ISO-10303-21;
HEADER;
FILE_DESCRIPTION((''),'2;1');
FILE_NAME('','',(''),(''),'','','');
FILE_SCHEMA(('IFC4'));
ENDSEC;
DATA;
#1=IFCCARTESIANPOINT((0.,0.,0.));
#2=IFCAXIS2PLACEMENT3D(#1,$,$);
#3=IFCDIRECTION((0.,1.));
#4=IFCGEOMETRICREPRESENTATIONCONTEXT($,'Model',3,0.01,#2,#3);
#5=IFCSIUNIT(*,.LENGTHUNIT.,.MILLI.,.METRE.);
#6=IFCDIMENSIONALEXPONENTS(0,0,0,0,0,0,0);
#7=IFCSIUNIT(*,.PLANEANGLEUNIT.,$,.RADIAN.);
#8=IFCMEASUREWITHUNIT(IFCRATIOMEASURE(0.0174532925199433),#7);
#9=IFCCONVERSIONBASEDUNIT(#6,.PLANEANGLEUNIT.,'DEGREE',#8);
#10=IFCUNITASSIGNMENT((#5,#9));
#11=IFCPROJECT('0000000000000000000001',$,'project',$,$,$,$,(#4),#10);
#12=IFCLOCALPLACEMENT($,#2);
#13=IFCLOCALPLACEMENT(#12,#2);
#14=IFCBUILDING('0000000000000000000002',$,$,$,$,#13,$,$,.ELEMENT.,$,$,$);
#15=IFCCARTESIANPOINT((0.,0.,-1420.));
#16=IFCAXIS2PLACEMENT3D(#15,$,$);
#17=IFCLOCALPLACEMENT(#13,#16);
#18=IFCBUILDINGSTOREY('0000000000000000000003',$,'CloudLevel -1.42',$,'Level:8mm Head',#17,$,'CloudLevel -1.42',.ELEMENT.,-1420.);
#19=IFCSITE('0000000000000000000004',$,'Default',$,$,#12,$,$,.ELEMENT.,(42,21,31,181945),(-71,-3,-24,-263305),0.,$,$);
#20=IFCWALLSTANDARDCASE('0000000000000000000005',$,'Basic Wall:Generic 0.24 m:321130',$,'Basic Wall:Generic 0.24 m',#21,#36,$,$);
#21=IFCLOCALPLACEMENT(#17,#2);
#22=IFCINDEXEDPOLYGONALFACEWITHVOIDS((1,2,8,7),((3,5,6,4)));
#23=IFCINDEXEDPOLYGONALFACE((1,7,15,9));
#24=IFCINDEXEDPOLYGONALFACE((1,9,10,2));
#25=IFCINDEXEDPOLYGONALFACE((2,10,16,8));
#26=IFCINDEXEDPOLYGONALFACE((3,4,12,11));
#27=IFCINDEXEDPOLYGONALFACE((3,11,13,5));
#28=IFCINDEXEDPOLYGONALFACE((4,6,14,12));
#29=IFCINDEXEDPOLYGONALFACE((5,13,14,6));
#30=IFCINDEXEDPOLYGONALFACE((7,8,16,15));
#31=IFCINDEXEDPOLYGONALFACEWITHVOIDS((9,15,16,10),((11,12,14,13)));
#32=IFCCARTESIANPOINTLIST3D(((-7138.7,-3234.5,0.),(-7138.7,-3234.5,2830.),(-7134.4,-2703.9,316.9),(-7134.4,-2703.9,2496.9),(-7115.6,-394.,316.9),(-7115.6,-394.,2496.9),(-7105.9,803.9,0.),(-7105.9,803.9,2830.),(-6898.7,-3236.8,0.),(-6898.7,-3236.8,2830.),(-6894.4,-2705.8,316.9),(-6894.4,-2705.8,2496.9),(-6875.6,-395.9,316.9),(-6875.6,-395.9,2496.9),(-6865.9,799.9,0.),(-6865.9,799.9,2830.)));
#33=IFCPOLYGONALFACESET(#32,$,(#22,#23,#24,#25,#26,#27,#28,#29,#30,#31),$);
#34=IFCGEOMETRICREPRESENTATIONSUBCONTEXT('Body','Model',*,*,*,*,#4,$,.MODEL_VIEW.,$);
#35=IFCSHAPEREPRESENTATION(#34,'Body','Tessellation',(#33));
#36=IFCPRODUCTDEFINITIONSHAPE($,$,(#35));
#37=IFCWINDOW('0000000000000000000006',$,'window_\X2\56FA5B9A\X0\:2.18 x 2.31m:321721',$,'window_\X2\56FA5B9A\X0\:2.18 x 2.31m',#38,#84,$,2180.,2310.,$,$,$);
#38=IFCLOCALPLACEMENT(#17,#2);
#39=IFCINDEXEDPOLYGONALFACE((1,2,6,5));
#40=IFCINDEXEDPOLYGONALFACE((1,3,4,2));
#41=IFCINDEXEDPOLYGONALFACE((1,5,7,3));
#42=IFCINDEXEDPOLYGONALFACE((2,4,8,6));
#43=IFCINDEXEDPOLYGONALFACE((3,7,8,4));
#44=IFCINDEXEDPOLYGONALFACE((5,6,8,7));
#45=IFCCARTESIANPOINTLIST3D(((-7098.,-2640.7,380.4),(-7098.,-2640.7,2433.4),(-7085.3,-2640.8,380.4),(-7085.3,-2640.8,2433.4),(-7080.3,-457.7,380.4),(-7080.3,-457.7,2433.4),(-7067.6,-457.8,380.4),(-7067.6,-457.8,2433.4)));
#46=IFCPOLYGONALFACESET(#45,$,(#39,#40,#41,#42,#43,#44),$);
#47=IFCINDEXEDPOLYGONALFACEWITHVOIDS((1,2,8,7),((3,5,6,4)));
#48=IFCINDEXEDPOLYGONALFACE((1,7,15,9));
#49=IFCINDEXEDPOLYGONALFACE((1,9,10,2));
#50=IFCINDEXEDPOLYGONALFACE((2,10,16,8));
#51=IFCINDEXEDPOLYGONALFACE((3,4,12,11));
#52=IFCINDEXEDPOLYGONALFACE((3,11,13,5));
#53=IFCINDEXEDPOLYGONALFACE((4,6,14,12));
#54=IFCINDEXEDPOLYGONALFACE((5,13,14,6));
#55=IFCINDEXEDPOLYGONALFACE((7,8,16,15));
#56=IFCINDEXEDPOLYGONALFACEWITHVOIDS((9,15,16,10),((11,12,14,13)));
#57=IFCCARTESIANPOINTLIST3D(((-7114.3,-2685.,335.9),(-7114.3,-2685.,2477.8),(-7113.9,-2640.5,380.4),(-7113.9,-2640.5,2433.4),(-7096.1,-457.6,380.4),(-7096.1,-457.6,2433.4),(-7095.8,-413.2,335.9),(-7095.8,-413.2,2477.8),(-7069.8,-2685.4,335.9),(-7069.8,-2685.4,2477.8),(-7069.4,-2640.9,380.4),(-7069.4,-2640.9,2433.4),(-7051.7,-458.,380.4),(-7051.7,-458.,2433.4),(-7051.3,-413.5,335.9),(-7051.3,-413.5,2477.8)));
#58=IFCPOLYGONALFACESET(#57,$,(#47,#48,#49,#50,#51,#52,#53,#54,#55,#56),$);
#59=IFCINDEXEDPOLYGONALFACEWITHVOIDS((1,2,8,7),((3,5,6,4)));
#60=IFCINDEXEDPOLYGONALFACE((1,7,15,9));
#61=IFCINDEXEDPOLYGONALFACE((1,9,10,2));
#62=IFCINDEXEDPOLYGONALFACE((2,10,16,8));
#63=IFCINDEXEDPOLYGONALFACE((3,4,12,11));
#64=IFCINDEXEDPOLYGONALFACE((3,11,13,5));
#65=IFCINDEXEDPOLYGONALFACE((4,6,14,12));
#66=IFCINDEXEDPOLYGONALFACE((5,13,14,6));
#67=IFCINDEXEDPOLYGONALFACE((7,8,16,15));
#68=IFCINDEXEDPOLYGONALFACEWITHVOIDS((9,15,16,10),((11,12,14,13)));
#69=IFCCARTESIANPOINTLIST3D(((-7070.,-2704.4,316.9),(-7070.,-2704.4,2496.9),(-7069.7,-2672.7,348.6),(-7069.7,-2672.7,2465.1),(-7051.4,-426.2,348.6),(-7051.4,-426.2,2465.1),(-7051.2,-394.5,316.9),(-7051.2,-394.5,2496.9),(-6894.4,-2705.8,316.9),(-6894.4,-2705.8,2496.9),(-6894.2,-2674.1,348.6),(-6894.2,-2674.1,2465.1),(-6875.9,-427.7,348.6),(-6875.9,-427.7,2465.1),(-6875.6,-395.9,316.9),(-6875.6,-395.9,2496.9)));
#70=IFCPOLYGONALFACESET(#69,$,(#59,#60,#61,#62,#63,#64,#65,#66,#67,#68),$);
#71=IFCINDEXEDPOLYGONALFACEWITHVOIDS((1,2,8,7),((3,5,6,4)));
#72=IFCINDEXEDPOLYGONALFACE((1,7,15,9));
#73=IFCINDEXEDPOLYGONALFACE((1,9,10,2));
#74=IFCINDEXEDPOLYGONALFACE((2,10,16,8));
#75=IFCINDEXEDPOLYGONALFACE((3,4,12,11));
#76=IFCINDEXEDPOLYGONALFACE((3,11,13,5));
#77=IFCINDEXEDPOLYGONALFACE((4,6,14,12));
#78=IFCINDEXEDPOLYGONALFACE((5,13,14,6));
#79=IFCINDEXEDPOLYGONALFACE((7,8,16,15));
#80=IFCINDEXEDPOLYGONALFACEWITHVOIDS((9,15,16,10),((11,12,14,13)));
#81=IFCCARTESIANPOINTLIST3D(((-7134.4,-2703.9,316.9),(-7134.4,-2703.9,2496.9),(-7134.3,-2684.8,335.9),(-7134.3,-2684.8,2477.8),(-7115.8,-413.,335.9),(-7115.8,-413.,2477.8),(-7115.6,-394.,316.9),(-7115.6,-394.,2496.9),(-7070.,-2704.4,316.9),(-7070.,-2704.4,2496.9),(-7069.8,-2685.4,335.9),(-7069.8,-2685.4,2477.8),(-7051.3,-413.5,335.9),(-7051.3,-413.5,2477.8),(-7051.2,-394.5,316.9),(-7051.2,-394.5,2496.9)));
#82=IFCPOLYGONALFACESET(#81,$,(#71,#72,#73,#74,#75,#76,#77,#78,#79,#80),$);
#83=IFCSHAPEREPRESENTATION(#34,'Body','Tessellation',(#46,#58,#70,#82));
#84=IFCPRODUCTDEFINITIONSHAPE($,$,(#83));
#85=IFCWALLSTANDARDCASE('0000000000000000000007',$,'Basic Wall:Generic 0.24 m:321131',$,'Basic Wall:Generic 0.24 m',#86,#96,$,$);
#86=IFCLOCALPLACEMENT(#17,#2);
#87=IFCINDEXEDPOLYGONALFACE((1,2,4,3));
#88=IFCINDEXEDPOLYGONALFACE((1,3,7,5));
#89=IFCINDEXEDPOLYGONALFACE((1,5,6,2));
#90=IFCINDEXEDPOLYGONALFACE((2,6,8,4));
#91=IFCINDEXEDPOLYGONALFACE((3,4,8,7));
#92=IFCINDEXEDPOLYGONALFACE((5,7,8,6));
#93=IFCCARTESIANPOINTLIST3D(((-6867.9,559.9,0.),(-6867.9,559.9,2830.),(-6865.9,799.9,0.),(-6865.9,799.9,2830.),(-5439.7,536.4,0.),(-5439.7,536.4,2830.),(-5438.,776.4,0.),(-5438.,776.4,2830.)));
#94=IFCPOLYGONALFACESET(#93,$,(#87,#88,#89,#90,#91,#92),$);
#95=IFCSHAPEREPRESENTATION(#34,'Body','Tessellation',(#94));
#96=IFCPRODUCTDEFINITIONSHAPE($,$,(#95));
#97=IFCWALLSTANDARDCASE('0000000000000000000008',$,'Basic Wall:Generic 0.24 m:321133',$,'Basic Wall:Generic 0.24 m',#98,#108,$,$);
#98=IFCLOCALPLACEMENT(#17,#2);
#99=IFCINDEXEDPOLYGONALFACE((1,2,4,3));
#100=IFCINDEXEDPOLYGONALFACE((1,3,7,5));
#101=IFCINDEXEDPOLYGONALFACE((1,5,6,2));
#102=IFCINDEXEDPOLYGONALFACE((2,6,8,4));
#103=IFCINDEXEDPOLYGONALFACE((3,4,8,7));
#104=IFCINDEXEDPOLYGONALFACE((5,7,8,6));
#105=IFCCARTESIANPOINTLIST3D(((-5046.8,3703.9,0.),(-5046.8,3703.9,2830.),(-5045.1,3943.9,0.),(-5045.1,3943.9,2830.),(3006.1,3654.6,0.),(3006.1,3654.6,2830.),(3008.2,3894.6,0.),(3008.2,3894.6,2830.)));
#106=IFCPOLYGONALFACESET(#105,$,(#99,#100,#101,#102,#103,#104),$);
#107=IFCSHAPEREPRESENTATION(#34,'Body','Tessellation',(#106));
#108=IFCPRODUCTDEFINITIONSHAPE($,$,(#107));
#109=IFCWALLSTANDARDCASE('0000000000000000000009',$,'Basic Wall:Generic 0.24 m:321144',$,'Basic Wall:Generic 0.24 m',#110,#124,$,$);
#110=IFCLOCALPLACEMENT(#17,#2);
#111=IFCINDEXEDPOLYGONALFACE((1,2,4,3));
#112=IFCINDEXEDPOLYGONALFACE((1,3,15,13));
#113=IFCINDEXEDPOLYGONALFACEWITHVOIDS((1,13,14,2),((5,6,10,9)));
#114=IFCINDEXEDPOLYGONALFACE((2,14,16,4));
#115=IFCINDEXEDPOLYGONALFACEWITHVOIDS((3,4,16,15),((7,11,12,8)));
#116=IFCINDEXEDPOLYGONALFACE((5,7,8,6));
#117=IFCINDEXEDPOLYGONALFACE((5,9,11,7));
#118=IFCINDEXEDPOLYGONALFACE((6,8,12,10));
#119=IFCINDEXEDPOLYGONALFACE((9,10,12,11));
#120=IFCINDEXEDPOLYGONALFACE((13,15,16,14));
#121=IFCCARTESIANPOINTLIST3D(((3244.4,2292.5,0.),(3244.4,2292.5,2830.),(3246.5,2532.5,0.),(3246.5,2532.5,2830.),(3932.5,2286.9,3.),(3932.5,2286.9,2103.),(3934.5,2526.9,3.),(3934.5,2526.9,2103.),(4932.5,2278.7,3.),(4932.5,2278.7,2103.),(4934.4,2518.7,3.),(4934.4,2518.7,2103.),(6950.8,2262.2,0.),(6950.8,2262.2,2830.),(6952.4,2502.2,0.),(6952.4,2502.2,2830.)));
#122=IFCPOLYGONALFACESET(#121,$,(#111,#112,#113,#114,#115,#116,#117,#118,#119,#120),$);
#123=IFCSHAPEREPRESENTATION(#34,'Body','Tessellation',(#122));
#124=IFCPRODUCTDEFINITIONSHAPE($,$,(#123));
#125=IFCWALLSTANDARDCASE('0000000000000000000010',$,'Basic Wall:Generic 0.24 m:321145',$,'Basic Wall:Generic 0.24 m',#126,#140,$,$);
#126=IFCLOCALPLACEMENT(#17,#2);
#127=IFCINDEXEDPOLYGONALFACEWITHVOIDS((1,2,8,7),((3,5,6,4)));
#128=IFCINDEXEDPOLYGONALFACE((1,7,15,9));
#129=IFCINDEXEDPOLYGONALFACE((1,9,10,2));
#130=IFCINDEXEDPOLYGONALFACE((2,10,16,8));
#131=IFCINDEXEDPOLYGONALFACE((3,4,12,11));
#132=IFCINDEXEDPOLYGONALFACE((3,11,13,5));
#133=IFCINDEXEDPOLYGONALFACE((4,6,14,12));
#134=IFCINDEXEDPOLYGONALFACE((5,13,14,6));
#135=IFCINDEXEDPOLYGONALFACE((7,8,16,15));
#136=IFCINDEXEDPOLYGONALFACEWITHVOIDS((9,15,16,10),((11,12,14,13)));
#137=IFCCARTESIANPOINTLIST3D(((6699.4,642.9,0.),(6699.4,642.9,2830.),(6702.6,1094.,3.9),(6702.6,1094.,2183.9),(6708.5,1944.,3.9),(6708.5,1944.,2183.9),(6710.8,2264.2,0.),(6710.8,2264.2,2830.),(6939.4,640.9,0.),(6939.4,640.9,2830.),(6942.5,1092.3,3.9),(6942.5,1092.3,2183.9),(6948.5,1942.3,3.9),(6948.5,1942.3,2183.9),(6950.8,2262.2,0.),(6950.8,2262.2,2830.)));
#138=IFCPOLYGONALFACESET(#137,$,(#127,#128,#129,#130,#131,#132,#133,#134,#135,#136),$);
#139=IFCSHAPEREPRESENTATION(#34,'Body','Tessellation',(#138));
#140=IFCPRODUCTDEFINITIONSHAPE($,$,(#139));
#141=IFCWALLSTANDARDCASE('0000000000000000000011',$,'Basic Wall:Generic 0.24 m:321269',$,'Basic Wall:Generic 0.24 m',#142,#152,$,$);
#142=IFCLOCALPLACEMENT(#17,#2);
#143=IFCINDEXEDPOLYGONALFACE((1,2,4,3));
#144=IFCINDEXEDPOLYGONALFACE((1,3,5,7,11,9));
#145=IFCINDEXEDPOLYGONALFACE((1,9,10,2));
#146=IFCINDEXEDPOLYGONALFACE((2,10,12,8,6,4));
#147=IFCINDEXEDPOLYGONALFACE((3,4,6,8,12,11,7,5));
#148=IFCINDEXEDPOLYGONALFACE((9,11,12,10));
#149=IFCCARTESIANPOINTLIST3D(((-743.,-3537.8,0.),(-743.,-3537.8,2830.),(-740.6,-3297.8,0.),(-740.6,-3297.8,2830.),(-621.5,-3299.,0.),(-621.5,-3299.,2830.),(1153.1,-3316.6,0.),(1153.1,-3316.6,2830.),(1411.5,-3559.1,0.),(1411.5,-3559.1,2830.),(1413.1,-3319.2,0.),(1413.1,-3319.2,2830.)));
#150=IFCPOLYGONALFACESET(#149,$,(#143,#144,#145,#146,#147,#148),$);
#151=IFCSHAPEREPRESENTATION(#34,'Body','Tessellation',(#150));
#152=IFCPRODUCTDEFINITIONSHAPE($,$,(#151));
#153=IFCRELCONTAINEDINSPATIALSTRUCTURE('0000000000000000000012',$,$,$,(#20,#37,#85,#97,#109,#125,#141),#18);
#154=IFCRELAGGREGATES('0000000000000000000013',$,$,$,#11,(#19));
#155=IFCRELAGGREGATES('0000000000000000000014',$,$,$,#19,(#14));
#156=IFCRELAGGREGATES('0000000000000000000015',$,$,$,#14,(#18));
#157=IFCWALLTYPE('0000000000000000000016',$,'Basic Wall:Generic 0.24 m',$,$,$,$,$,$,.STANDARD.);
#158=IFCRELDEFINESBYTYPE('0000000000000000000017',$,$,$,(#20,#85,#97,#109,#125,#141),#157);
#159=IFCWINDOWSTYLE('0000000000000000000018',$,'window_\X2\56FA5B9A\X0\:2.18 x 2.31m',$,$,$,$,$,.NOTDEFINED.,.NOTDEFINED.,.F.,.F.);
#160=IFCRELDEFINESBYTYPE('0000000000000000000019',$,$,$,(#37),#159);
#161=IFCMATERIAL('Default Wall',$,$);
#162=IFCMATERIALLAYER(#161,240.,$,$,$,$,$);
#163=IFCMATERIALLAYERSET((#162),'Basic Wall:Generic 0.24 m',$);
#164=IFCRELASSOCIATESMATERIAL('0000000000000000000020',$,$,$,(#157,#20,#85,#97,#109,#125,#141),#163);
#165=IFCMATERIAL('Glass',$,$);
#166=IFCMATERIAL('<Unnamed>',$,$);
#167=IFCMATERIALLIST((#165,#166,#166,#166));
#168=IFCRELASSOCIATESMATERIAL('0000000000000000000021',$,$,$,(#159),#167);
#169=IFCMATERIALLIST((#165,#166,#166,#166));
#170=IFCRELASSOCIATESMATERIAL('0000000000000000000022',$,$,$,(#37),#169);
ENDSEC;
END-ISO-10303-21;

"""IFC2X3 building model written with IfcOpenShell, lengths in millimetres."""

from ifc_helpers import new_model, entity, si_unit, converted_unit, direction, frame, frame_2d, origin, place, context, subcontext, project, spatial, polyline, rectangle, outline, extrude, source, transform, mapped, material, material_list, layer, layer_set, layer_usage, type_object, type_shapes, element, fill, save


model = new_model("IFC2X3")

# Units and contexts
model_context = context("Model", 3, precision=0.01, world=origin(), true_north=direction((0.0, 1.0)))
body_context = subcontext(model_context, "Body", "Model", "MODEL_VIEW")
ifc_project = project(units=[si_unit("LENGTHUNIT", "METRE", prefix="MILLI"), converted_unit("PLANEANGLEUNIT", "DEGREE", entity("IfcRatioMeasure", 0.0174532925199433), si_unit("PLANEANGLEUNIT", "RADIAN"), dimensions=[0, 0, 0, 0, 0, 0, 0])], contexts=[model_context])

# Site, building, storey
site_placement = place(None, origin())
site = spatial("IfcSite", under=ifc_project, at=site_placement, Name="Default", CompositionType="ELEMENT", RefLatitude=(42, 21, 31, 181945), RefLongitude=(-71, -3, -24, -263305), RefElevation=0.0)
building_placement = place(site_placement, origin())
building = spatial("IfcBuilding", under=site, at=building_placement, CompositionType="ELEMENT")
storey_placement = place(building_placement, frame((0.0, 0.0, -1420.0)))
storey = spatial("IfcBuildingStorey", under=building, at=storey_placement, Name="CloudLevel -1.42", ObjectType="Level:8mm Head", LongName="CloudLevel -1.42", CompositionType="ELEMENT", Elevation=-1420.0)

# Shared definitions
ifc_material_1 = material(Name="Default Wall")
ifc_layer_1 = layer(ifc_material_1, 240.0)
ifc_layer_set_1 = layer_set([ifc_layer_1], Name="Basic Wall:Generic 0.24 m")
wall_type_1 = type_object("IfcWallType", Name="Basic Wall:Generic 0.24 m", PredefinedType="STANDARD", material=ifc_layer_set_1)
ifc_material_2 = material(Name="Glass")
ifc_material_3 = material(Name="<Unnamed>")

# Wall, opening, window
ifc_layer_usage_1 = layer_usage(ifc_layer_set_1, "AXIS2", "NEGATIVE", 120.0)
wall_1_placement = place(storey_placement, frame((-6985.9, 802.9, 0.0), z_axis=(0.0, 0.0, 1.0), x_axis=(-0.008134, -0.999967, 0.0)))
wall_1 = element("IfcWallStandardCase", 1, at=wall_1_placement, inside=storey, type_object=wall_type_1, material=ifc_layer_usage_1, Name="Basic Wall:Generic 0.24 m:321130", ObjectType="Basic Wall:Generic 0.24 m", context=body_context, shape_type="SweptSolid", body=[
    extrude(outline(polyline([(4038.5, -120.0), (4038.9, 120.0), (242.0, 120.0), (2.0, 120.0), (0.0, -120.0), (4038.5, -120.0)])), origin(), (0.0, 0.0, 1.0), 2830.0),
])
opening_1_placement = place(wall_1_placement, frame((3507.9, 120.0, 316.9)))
opening_1 = element("IfcOpeningElement", 2, at=opening_1_placement, cuts=wall_1, ObjectType="Opening", context=body_context, shape_type="SweptSolid", body=[
    extrude(rectangle(XDim=2180.0, YDim=2310.0, at=frame_2d((1090.0, 1155.0), x_axis=(-1.0, 0.0))), frame((0.0, 0.0, 0.0), z_axis=(0.0, -1.0, 0.0), x_axis=(0.0, 0.0, 1.0)), (0.0, 0.0, 1.0), 240.0),
])
ifc_material_list_1 = material_list([ifc_material_2, ifc_material_3, ifc_material_3, ifc_material_3])
ifc_material_list_2 = material_list([ifc_material_2, ifc_material_3, ifc_material_3, ifc_material_3])
window_style_1 = type_object("IfcWindowStyle", Name="window_固定:2.18 x 2.31m", ConstructionType="NOTDEFINED", OperationType="NOTDEFINED", ParameterTakesPrecedence=False, Sizeable=False, material=ifc_material_list_2)
shared_shape_1 = source(origin(), body_context, "Body", "SweptSolid", [
    extrude(rectangle(XDim=2183.0, YDim=12.7, at=frame_2d((0.0, 0.0), x_axis=(1.0, 0.0))), frame((1231.2, 197.8, 63.5)), (0.0, 0.0, 1.0), 2053.0),
    extrude(outline(polyline([(-1135.9, -1070.9), (1135.9, -1070.9), (1135.9, 1070.9), (-1135.9, 1070.9), (-1135.9, -1070.9)]), holes=[polyline([(-1091.5, -1026.5), (-1091.5, 1026.5), (1091.5, 1026.5), (1091.5, -1026.5), (-1091.5, -1026.5)])]), frame((1231.2, 220.0, 1090.0), z_axis=(0.0, -1.0, 0.0), x_axis=(-1.0, 0.0, 0.0)), (0.0, 0.0, 1.0), 44.5),
    extrude(outline(polyline([(-1155.0, -1090.0), (1155.0, -1090.0), (1155.0, 1090.0), (-1155.0, 1090.0), (-1155.0, -1090.0)]), holes=[polyline([(-1123.2, -1058.2), (-1123.2, 1058.2), (1123.2, 1058.2), (1123.2, -1058.2), (-1123.2, -1058.2)])]), frame((1231.2, 175.5, 1090.0), z_axis=(0.0, -1.0, 0.0), x_axis=(-1.0, 0.0, 0.0)), (0.0, 0.0, 1.0), 175.5),
    extrude(outline(polyline([(-1090.0, -1155.0), (1090.0, -1155.0), (1090.0, 1155.0), (-1090.0, 1155.0), (-1090.0, -1155.0)]), holes=[polyline([(-1070.9, -1135.9), (-1070.9, 1135.9), (1070.9, 1135.9), (1070.9, -1135.9), (-1070.9, -1135.9)])]), frame((1231.2, 240.0, 1090.0), z_axis=(0.0, -1.0, 0.0), x_axis=(0.0, 0.0, -1.0)), (0.0, 0.0, 1.0), 64.5),
])
type_shapes(window_style_1, [shared_shape_1])
window_1_placement = place(opening_1_placement, frame((76.2, 0.0, 0.0), z_axis=(0.0, 0.0, 1.0), x_axis=(-1.0, 0.0, 0.0)))
window_1 = element("IfcWindow", 3, at=window_1_placement, inside=storey, type_object=window_style_1, material=ifc_material_list_1, Name="window_固定:2.18 x 2.31m:321721", ObjectType="window_固定:2.18 x 2.31m", OverallHeight=2180.0, OverallWidth=2310.0, context=body_context, shape_type="MappedRepresentation", body=[
    mapped(shared_shape_1, transform((0.0, 0.0, 0.0), scale=1.0)),
])
fill(opening_1, window_1)

# Walls
ifc_layer_usage_2 = layer_usage(ifc_layer_set_1, "AXIS2", "NEGATIVE", 120.0)
wall_2_placement = place(storey_placement, frame((-5437.8, 656.4, 0.0), z_axis=(0.0, 0.0, 1.0), x_axis=(-0.999864, 0.016491, 0.0)))
element("IfcWallStandardCase", 4, at=wall_2_placement, inside=storey, type_object=wall_type_1, material=ifc_layer_usage_2, Name="Basic Wall:Generic 0.24 m:321131", ObjectType="Basic Wall:Generic 0.24 m", context=body_context, shape_type="SweptSolid", body=[
    extrude(outline(polyline([(1430.3, -120.0), (1428.3, 120.0), (0.0, 120.0), (2.2, -120.0), (1430.3, -120.0)])), origin(), (0.0, 0.0, 1.0), 2830.0),
])
ifc_layer_usage_3 = layer_usage(ifc_layer_set_1, "AXIS2", "NEGATIVE", 120.0)
wall_3_placement = place(storey_placement, frame((3007.4, 3774.6, 0.0), z_axis=(0.0, 0.0, 1.0), x_axis=(-0.999981, 0.00613, 0.0)))
element("IfcWallStandardCase", 5, at=wall_3_placement, inside=storey, type_object=wall_type_1, material=ifc_layer_usage_3, Name="Basic Wall:Generic 0.24 m:321133", ObjectType="Basic Wall:Generic 0.24 m", context=body_context, shape_type="SweptSolid", body=[
    extrude(outline(polyline([(8053.4, -120.0), (8053.7, 120.0), (0.6, 120.0), (0.0, -120.0), (8053.4, -120.0)])), origin(), (0.0, 0.0, 1.0), 2830.0),
])

# Walls, openings
ifc_layer_usage_4 = layer_usage(ifc_layer_set_1, "AXIS2", "NEGATIVE", 120.0)
wall_4_placement = place(storey_placement, frame((3245.4, 2412.5, 0.0), z_axis=(0.0, 0.0, 1.0), x_axis=(0.999967, -0.008179, 0.0)))
wall_4 = element("IfcWallStandardCase", 6, at=wall_4_placement, inside=storey, type_object=wall_type_1, material=ifc_layer_usage_4, Name="Basic Wall:Generic 0.24 m:321144", ObjectType="Basic Wall:Generic 0.24 m", context=body_context, shape_type="SweptSolid", body=[
    extrude(outline(polyline([(3706.4, -120.0), (3706.2, 120.0), (0.1, 120.0), (0.0, -120.0), (3466.4, -120.0), (3706.4, -120.0)])), origin(), (0.0, 0.0, 1.0), 2830.0),
])
opening_2_placement = place(wall_4_placement, frame((688.1, -120.0, 3.0)))
element("IfcOpeningElement", 7, at=opening_2_placement, cuts=wall_4, ObjectType="Opening", context=body_context, shape_type="SweptSolid", body=[
    extrude(rectangle(XDim=1000.0, YDim=2100.0, at=frame_2d((1050.0, 500.0), x_axis=(0.0, 1.0))), frame((0.0, 0.0, 0.0), z_axis=(0.0, 1.0, 0.0), x_axis=(0.0, 0.0, 1.0)), (0.0, 0.0, 1.0), 240.0),
])
ifc_layer_usage_5 = layer_usage(ifc_layer_set_1, "AXIS2", "NEGATIVE", 120.0)
wall_5_placement = place(storey_placement, frame((6830.8, 2263.4, 0.0), z_axis=(0.0, 0.0, 1.0), x_axis=(-0.007012, -0.999975, 0.0)))
wall_5 = element("IfcWallStandardCase", 8, at=wall_5_placement, inside=storey, type_object=wall_type_1, material=ifc_layer_usage_5, Name="Basic Wall:Generic 0.24 m:321145", ObjectType="Basic Wall:Generic 0.24 m", context=body_context, shape_type="SweptSolid", body=[
    extrude(outline(polyline([(1621.3, -120.0), (1621.3, -119.4), (1621.6, 120.0), (0.3, 120.0), (0.0, -120.0), (1621.3, -120.0)])), origin(), (0.0, 0.0, 1.0), 2830.0),
])
opening_3_placement = place(wall_5_placement, frame((320.2, -120.0, 3.9)))
element("IfcOpeningElement", 9, at=opening_3_placement, cuts=wall_5, ObjectType="Opening", context=body_context, shape_type="SweptSolid", body=[
    extrude(rectangle(XDim=850.0, YDim=2180.0, at=frame_2d((1090.0, 425.0), x_axis=(0.0, 1.0))), frame((0.0, 0.0, 0.0), z_axis=(0.0, 1.0, 0.0), x_axis=(0.0, 0.0, 1.0)), (0.0, 0.0, 1.0), 240.0),
])

# Wall
ifc_layer_usage_6 = layer_usage(ifc_layer_set_1, "AXIS2", "NEGATIVE", 120.0)
wall_6_placement = place(storey_placement, frame((-741.8, -3417.8, 0.0), z_axis=(0.0, 0.0, 1.0), x_axis=(0.999951, -0.009904, 0.0)))
element("IfcWallStandardCase", 10, at=wall_6_placement, inside=storey, type_object=wall_type_1, material=ifc_layer_usage_6, Name="Basic Wall:Generic 0.24 m:321269", ObjectType="Basic Wall:Generic 0.24 m", context=body_context, shape_type="SweptSolid", body=[
    extrude(outline(polyline([(2154.6, -120.0), (2153.9, 120.0), (1893.9, 120.0), (119.1, 120.0), (0.0, 120.0), (0.0, -120.0), (2154.6, -120.0)])), origin(), (0.0, 0.0, 1.0), 2830.0),
])

save(model, "model.ifc")
